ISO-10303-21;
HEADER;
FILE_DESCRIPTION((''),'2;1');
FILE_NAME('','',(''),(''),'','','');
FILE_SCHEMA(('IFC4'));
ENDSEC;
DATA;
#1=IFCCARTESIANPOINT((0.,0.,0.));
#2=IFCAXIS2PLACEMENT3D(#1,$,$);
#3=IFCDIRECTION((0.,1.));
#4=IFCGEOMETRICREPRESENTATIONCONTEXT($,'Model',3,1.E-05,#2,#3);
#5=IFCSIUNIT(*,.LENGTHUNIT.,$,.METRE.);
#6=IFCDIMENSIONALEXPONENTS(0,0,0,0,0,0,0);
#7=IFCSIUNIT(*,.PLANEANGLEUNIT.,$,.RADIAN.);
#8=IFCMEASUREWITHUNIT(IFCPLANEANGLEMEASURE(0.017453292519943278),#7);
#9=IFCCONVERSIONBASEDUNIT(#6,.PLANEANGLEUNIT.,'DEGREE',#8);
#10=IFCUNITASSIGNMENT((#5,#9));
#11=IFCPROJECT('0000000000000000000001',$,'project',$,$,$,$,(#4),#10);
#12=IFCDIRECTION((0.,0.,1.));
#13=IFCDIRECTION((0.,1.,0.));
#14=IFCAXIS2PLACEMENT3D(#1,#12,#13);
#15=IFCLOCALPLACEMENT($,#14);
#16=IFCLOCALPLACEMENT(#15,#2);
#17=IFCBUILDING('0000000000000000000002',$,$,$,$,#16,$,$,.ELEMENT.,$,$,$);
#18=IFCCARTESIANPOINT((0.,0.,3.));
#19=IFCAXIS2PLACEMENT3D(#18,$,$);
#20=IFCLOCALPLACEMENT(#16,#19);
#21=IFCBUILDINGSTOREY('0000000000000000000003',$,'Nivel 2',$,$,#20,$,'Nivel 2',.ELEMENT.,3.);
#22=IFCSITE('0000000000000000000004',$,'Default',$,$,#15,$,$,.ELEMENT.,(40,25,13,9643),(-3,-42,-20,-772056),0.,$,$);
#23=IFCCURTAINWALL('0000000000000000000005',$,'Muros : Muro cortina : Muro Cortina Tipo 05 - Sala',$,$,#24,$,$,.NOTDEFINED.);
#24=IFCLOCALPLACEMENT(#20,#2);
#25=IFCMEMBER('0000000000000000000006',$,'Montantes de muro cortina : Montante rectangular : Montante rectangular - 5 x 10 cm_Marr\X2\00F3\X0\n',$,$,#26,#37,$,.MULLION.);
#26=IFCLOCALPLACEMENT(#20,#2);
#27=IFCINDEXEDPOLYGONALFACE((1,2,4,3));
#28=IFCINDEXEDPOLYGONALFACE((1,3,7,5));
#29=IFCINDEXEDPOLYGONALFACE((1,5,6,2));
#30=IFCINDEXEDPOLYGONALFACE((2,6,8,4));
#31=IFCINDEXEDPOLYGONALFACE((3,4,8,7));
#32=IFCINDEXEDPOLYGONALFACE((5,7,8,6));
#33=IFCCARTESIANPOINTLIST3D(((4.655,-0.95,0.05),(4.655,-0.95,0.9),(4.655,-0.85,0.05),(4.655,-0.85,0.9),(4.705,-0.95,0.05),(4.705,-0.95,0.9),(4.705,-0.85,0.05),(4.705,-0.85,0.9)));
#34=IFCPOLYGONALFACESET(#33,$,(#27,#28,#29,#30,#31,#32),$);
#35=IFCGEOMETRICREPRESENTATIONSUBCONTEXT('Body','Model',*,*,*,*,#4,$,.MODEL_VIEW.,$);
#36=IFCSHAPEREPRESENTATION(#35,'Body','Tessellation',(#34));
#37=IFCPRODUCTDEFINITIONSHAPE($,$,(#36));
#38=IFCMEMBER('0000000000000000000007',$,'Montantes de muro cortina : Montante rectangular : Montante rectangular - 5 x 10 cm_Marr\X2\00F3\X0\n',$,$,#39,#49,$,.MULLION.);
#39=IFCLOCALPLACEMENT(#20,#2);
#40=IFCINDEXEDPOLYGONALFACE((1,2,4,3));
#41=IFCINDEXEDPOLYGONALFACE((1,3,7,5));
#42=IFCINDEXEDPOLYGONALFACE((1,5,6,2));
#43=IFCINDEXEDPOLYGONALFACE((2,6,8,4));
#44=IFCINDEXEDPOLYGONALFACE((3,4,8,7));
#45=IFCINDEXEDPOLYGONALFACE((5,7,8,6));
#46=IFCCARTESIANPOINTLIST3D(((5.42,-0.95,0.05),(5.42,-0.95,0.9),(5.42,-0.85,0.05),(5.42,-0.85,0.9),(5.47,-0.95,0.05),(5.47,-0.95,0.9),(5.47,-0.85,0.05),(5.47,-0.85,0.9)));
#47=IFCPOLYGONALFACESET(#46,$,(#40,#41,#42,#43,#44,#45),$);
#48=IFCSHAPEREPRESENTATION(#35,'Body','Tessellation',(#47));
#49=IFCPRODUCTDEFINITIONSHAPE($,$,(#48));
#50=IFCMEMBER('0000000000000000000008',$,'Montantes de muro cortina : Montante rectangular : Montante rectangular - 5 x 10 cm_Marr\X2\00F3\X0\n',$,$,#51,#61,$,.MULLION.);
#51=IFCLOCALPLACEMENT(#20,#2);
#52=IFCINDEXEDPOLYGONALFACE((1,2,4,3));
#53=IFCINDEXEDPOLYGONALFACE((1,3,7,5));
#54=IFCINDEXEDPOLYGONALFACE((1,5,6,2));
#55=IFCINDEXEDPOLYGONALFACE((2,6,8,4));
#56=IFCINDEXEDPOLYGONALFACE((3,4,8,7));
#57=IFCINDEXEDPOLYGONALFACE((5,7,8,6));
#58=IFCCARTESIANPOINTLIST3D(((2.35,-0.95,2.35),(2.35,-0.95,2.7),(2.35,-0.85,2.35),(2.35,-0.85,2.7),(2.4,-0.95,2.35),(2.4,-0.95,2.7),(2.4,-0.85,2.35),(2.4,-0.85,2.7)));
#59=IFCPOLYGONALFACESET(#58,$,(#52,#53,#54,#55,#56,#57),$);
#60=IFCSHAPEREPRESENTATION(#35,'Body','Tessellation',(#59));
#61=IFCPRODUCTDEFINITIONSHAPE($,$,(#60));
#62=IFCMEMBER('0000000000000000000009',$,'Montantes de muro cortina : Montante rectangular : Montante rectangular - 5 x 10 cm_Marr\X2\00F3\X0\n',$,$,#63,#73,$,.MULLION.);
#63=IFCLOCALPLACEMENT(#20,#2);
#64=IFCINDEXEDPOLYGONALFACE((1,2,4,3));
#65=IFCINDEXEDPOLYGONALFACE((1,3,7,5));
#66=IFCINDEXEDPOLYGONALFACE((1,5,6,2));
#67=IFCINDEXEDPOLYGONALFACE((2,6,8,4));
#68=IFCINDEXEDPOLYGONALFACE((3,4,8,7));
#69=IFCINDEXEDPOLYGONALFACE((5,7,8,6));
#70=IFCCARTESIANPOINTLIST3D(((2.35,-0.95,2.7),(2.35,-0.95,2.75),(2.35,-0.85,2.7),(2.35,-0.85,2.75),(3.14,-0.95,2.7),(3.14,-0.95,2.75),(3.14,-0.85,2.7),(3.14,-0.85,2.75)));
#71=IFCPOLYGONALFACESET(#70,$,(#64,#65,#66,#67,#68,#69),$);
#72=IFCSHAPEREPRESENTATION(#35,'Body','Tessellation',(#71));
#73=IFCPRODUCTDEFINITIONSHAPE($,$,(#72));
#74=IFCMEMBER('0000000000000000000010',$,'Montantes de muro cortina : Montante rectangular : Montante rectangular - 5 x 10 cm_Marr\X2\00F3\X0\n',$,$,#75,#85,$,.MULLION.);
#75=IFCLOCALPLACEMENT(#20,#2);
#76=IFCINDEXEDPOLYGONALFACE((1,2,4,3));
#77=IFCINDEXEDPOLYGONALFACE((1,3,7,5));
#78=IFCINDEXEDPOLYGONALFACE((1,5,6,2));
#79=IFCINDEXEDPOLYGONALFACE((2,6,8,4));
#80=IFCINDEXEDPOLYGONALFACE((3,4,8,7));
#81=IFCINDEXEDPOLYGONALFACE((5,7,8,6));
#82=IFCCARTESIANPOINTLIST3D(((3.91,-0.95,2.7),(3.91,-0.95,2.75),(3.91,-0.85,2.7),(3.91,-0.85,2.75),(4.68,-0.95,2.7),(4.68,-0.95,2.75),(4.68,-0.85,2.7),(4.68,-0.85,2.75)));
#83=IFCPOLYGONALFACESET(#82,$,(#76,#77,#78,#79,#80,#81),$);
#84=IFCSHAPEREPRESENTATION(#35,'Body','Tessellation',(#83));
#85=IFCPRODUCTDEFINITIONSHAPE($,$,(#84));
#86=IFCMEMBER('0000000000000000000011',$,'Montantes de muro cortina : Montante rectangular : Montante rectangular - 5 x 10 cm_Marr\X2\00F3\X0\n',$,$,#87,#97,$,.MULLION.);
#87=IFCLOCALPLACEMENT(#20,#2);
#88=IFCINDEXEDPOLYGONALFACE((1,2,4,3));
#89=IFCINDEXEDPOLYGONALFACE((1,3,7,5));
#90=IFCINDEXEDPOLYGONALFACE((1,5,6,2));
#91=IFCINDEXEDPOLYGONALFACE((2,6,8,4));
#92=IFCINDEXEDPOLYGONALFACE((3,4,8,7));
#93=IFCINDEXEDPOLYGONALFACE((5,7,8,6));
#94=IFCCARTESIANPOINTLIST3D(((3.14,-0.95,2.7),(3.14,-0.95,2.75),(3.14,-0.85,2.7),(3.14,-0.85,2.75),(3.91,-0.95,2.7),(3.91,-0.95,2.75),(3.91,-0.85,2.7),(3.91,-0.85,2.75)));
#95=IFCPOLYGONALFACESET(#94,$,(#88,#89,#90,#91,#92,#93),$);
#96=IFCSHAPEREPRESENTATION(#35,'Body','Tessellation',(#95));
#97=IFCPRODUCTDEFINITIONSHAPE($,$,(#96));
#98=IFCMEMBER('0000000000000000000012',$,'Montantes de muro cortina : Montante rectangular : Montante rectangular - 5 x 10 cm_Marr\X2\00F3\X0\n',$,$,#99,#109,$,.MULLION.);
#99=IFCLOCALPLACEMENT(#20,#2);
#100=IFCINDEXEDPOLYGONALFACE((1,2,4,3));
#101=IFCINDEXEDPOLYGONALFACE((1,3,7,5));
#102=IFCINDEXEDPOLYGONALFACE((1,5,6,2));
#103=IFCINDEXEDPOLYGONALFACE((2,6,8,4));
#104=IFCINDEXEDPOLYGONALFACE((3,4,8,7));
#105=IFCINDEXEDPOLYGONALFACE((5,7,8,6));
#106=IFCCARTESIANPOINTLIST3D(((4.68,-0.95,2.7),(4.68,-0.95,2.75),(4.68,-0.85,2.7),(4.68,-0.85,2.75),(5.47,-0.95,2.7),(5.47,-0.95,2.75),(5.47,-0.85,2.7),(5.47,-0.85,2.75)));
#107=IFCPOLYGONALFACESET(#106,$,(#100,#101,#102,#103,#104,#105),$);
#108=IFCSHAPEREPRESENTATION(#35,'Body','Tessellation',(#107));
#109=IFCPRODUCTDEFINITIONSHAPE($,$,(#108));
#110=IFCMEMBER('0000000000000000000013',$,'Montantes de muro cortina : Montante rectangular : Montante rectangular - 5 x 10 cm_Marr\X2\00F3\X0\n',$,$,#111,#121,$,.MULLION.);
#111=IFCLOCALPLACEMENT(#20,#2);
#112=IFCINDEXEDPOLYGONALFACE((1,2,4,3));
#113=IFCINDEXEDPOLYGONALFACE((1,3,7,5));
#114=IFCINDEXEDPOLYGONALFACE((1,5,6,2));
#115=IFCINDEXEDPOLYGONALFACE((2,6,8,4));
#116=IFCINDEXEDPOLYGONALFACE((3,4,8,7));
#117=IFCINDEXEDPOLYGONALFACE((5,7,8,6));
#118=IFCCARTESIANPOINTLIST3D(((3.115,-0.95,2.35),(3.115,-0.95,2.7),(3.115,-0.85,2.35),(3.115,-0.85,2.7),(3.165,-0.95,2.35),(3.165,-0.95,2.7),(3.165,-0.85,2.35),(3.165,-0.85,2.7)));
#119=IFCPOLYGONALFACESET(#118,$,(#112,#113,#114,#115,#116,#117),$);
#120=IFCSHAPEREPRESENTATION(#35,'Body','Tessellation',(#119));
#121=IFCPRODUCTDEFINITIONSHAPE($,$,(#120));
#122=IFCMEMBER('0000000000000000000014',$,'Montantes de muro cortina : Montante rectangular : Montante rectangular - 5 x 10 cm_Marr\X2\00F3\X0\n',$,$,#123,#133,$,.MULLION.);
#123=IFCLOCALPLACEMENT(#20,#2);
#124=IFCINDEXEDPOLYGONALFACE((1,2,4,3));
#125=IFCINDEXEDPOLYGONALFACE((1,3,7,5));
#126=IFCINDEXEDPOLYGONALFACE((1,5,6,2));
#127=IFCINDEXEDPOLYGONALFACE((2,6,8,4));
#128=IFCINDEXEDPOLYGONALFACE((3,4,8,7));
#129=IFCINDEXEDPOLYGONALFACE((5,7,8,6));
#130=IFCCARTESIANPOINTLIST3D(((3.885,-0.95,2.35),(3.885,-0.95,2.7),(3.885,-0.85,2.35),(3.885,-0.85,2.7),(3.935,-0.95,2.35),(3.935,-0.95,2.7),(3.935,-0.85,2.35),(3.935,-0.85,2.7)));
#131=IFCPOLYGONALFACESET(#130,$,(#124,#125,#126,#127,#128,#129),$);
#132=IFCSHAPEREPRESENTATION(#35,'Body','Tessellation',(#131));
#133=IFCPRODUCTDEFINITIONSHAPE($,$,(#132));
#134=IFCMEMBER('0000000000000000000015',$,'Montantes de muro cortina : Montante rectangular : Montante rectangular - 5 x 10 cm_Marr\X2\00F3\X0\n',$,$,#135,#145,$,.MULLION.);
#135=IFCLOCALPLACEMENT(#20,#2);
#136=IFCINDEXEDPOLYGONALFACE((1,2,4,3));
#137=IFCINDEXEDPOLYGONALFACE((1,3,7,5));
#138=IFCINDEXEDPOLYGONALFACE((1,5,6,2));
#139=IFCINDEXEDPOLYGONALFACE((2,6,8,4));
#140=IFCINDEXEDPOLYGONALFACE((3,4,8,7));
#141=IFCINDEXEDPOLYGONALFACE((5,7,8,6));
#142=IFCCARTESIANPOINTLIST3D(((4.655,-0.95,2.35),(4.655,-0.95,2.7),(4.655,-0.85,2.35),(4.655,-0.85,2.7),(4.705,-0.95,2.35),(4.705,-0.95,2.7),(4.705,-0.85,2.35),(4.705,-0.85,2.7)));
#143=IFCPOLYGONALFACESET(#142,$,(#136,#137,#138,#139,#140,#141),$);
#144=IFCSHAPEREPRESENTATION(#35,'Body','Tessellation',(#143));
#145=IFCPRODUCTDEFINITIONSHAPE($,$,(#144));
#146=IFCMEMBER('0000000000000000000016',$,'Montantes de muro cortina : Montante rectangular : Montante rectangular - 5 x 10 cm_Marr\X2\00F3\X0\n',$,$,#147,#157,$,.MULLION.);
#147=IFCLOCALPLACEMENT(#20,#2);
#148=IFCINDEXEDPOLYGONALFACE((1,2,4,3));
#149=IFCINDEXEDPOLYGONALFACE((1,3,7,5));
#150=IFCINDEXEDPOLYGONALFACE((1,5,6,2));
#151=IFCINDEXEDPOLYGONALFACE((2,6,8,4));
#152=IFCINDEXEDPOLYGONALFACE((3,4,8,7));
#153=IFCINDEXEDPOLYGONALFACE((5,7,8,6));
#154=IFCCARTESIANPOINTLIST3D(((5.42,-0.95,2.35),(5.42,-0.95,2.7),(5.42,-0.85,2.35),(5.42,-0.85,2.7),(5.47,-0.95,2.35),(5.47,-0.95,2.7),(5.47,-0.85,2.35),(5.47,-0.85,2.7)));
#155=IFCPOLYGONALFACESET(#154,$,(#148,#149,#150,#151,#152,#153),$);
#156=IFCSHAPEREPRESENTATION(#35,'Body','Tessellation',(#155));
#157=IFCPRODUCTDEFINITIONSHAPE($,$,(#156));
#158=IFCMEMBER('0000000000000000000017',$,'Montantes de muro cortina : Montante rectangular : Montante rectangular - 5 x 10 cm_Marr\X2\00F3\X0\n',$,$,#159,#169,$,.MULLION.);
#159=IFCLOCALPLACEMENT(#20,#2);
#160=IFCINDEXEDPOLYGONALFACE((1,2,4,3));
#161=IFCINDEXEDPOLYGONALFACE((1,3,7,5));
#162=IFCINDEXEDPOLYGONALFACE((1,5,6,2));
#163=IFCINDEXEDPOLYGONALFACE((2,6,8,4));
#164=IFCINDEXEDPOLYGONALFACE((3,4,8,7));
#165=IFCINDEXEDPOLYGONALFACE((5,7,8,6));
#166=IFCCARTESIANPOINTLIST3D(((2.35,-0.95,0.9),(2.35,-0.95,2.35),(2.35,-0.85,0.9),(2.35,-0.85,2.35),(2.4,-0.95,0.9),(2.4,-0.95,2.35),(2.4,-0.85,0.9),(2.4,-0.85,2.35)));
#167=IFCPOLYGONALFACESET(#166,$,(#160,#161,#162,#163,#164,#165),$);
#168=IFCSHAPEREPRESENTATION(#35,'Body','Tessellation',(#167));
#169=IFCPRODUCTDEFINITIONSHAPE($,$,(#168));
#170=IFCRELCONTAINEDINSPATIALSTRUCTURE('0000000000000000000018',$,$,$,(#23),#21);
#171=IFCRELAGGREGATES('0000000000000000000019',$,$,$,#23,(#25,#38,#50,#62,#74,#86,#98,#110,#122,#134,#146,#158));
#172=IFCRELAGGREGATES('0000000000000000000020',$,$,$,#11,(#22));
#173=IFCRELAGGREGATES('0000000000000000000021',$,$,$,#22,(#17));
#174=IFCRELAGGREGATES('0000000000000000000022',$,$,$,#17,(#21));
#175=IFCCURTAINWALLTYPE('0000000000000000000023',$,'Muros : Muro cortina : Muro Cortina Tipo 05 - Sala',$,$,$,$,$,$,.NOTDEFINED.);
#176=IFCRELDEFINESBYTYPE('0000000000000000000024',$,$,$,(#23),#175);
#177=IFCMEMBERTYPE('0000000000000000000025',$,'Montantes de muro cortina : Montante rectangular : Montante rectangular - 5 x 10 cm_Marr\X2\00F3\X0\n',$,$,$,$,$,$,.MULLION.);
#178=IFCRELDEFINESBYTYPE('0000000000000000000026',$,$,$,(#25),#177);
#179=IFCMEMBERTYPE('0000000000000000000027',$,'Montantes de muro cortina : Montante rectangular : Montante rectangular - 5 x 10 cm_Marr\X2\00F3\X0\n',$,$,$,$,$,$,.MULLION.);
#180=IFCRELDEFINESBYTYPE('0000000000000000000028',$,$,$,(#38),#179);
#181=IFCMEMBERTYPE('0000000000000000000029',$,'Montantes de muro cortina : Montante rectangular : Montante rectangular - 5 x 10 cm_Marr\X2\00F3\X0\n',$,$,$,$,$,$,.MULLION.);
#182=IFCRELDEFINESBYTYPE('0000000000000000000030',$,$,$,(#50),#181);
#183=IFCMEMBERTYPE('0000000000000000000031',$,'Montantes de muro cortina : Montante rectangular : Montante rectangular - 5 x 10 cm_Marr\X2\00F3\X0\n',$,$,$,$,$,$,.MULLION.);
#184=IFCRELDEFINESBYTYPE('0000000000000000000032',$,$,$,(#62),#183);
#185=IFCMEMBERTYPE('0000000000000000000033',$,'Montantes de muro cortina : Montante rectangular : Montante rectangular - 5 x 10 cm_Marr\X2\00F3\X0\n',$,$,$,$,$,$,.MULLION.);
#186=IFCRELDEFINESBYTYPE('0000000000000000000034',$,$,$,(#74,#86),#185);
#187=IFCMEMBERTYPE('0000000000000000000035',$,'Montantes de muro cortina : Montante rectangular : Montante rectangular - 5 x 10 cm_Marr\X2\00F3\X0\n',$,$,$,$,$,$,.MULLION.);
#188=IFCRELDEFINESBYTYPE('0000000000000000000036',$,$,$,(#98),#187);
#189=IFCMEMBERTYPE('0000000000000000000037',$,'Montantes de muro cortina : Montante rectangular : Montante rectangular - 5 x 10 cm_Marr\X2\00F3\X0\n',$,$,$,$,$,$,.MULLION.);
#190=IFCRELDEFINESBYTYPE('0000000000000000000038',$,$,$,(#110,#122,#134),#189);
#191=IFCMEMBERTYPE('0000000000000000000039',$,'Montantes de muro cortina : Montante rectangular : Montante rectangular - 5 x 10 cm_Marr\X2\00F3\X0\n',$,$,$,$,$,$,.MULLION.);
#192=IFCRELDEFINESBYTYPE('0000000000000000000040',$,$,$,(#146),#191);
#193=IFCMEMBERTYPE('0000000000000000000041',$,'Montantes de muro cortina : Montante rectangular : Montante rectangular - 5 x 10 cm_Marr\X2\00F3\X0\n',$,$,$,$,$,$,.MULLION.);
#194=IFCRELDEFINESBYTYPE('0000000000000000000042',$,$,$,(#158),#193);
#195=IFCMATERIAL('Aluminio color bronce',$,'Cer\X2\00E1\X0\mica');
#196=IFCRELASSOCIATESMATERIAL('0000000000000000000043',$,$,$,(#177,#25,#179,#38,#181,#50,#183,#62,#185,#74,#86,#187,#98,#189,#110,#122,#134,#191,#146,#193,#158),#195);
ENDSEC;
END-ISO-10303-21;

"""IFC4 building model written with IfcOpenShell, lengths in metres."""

from ifc_helpers import new_model, entity, si_unit, converted_unit, direction, frame, origin, place, context, subcontext, project, spatial, indexed_curve, outline, extrude, source, transform, mapped, material, type_object, type_shapes, element, aggregate, save


model = new_model("IFC4")

# Units and contexts
model_context = context("Model", 3, precision=1e-05, world=origin(), true_north=direction((0.0, 1.0)))
body_context = subcontext(model_context, "Body", "Model", "MODEL_VIEW")
ifc_project = project(units=[si_unit("LENGTHUNIT", "METRE"), converted_unit("PLANEANGLEUNIT", "DEGREE", entity("IfcPlaneAngleMeasure", 0.017453292519943278), si_unit("PLANEANGLEUNIT", "RADIAN"), dimensions=[0, 0, 0, 0, 0, 0, 0])], contexts=[model_context])

# Site, building, storey
site_placement = place(None, frame((0.0, 0.0, 0.0), z_axis=(0.0, 0.0, 1.0), x_axis=(0.0, 1.0, 0.0)))
site = spatial("IfcSite", under=ifc_project, at=site_placement, Name="Default", CompositionType="ELEMENT", RefLatitude=(40, 25, 13, 9643), RefLongitude=(-3, -42, -20, -772056), RefElevation=0.0)
building_placement = place(site_placement, origin())
building = spatial("IfcBuilding", under=site, at=building_placement, CompositionType="ELEMENT")
storey_placement = place(building_placement, frame((0.0, 0.0, 3.0)))
storey = spatial("IfcBuildingStorey", under=building, at=storey_placement, Name="Nivel 2", LongName="Nivel 2", CompositionType="ELEMENT", Elevation=3.0)

# Curtain wall, members
curtain_wall_type = type_object("IfcCurtainWallType", Name="Muros : Muro cortina : Muro Cortina Tipo 05 - Sala", PredefinedType="NOTDEFINED")
curtain_wall_placement = place(storey_placement, frame((0.0, 0.0, -3.0)))
curtain_wall = element("IfcCurtainWall", 1, at=curtain_wall_placement, inside=storey, type_object=curtain_wall_type, Name="Muros : Muro cortina : Muro Cortina Tipo 05 - Sala", PredefinedType="NOTDEFINED")
ifc_material_1 = material(Name="Aluminio color bronce", Category="Cerámica")
member_type_1 = type_object("IfcMemberType", Name="Montantes de muro cortina : Montante rectangular : Montante rectangular - 5 x 10 cm_Marrón", PredefinedType="MULLION", material=ifc_material_1)
shared_shape_1 = source(origin(), body_context, "Body", "SweptSolid", [
    extrude(outline(indexed_curve([(-0.05, -0.025), (0.05, -0.025), (0.05, 0.025), (-0.05, 0.025), (-0.05, -0.025)], self_intersect=False)), frame((0.0, 0.0, -0.85), z_axis=(0.0, 0.0, 1.0), x_axis=(0.0, 1.0, 0.0)), (0.0, 0.0, 1.0), 0.85),
])
type_shapes(member_type_1, [shared_shape_1])
member_1_placement = place(curtain_wall_placement, frame((4.68, -0.9, 3.05), z_axis=(0.0, 0.0, -1.0), x_axis=(1.0, 0.0, 0.0)))
member_1 = element("IfcMember", 2, at=member_1_placement, type_object=member_type_1, material=ifc_material_1, Name="Montantes de muro cortina : Montante rectangular : Montante rectangular - 5 x 10 cm_Marrón", PredefinedType="MULLION", context=body_context, shape_type="MappedRepresentation", body=[
    mapped(shared_shape_1, transform((0.0, 0.0, 0.0), scale=1.0)),
])
member_type_2 = type_object("IfcMemberType", Name="Montantes de muro cortina : Montante rectangular : Montante rectangular - 5 x 10 cm_Marrón", PredefinedType="MULLION", material=ifc_material_1)
shared_shape_2 = source(origin(), body_context, "Body", "SweptSolid", [
    extrude(outline(indexed_curve([(-0.05, -0.025), (0.05, -0.025), (0.05, 0.025), (-0.05, 0.025), (-0.05, -0.025)], self_intersect=False)), frame((-0.025, 0.0, -0.85), z_axis=(0.0, 0.0, 1.0), x_axis=(0.0, 1.0, 0.0)), (0.0, 0.0, 1.0), 0.85),
])
type_shapes(member_type_2, [shared_shape_2])
member_2_placement = place(curtain_wall_placement, frame((5.47, -0.9, 3.05), z_axis=(0.0, 0.0, -1.0), x_axis=(1.0, 0.0, 0.0)))
member_2 = element("IfcMember", 3, at=member_2_placement, type_object=member_type_2, material=ifc_material_1, Name="Montantes de muro cortina : Montante rectangular : Montante rectangular - 5 x 10 cm_Marrón", PredefinedType="MULLION", context=body_context, shape_type="MappedRepresentation", body=[
    mapped(shared_shape_2, transform((0.0, 0.0, 0.0), scale=1.0)),
])
member_type_3 = type_object("IfcMemberType", Name="Montantes de muro cortina : Montante rectangular : Montante rectangular - 5 x 10 cm_Marrón", PredefinedType="MULLION", material=ifc_material_1)
shared_shape_3 = source(origin(), body_context, "Body", "SweptSolid", [
    extrude(outline(indexed_curve([(-0.025, -0.05), (0.025, -0.05), (0.025, 0.05), (-0.025, 0.05), (-0.025, -0.05)], self_intersect=False)), frame((-0.025, 0.0, -0.35)), (0.0, 0.0, 1.0), 0.35),
])
type_shapes(member_type_3, [shared_shape_3])
member_3_placement = place(curtain_wall_placement, frame((2.35, -0.9, 5.7), z_axis=(0.0, 0.0, 1.0), x_axis=(-1.0, 0.0, 0.0)))
member_3 = element("IfcMember", 4, at=member_3_placement, type_object=member_type_3, material=ifc_material_1, Name="Montantes de muro cortina : Montante rectangular : Montante rectangular - 5 x 10 cm_Marrón", PredefinedType="MULLION", context=body_context, shape_type="MappedRepresentation", body=[
    mapped(shared_shape_3, transform((0.0, 0.0, 0.0), scale=1.0)),
])
member_type_4 = type_object("IfcMemberType", Name="Montantes de muro cortina : Montante rectangular : Montante rectangular - 5 x 10 cm_Marrón", PredefinedType="MULLION", material=ifc_material_1)
shared_shape_4 = source(origin(), body_context, "Body", "SweptSolid", [
    extrude(outline(indexed_curve([(-0.05, -0.025), (0.05, -0.025), (0.05, 0.025), (-0.05, 0.025), (-0.05, -0.025)], self_intersect=False)), frame((-0.025, 0.0, -0.79), z_axis=(0.0, 0.0, 1.0), x_axis=(0.0, 1.0, 0.0)), (0.0, 0.0, 1.0), 0.79),
])
type_shapes(member_type_4, [shared_shape_4])
member_4_placement = place(curtain_wall_placement, frame((3.14, -0.9, 5.75), z_axis=(1.0, 0.0, 0.0), x_axis=(0.0, 0.0, 1.0)))
member_4 = element("IfcMember", 5, at=member_4_placement, type_object=member_type_4, material=ifc_material_1, Name="Montantes de muro cortina : Montante rectangular : Montante rectangular - 5 x 10 cm_Marrón", PredefinedType="MULLION", context=body_context, shape_type="MappedRepresentation", body=[
    mapped(shared_shape_4, transform((0.0, 0.0, 0.0), scale=1.0)),
])
member_type_5 = type_object("IfcMemberType", Name="Montantes de muro cortina : Montante rectangular : Montante rectangular - 5 x 10 cm_Marrón", PredefinedType="MULLION", material=ifc_material_1)
shared_shape_5 = source(origin(), body_context, "Body", "SweptSolid", [
    extrude(outline(indexed_curve([(-0.05, -0.025), (0.05, -0.025), (0.05, 0.025), (-0.05, 0.025), (-0.05, -0.025)], self_intersect=False)), frame((-0.025, 0.0, -0.77), z_axis=(0.0, 0.0, 1.0), x_axis=(0.0, 1.0, 0.0)), (0.0, 0.0, 1.0), 0.77),
])
type_shapes(member_type_5, [shared_shape_5])
member_5_placement = place(curtain_wall_placement, frame((4.68, -0.9, 5.75), z_axis=(1.0, 0.0, 0.0), x_axis=(0.0, 0.0, 1.0)))
member_5 = element("IfcMember", 6, at=member_5_placement, type_object=member_type_5, material=ifc_material_1, Name="Montantes de muro cortina : Montante rectangular : Montante rectangular - 5 x 10 cm_Marrón", PredefinedType="MULLION", context=body_context, shape_type="MappedRepresentation", body=[
    mapped(shared_shape_5, transform((0.0, 0.0, 0.0), scale=1.0)),
])
member_6_placement = place(curtain_wall_placement, frame((3.91, -0.9, 5.75), z_axis=(1.0, 0.0, 0.0), x_axis=(0.0, 0.0, 1.0)))
member_6 = element("IfcMember", 7, at=member_6_placement, type_object=member_type_5, material=ifc_material_1, Name="Montantes de muro cortina : Montante rectangular : Montante rectangular - 5 x 10 cm_Marrón", PredefinedType="MULLION", context=body_context, shape_type="MappedRepresentation", body=[
    mapped(shared_shape_5, transform((0.0, 0.0, 0.0), scale=1.0)),
])
member_type_6 = type_object("IfcMemberType", Name="Montantes de muro cortina : Montante rectangular : Montante rectangular - 5 x 10 cm_Marrón", PredefinedType="MULLION", material=ifc_material_1)
shared_shape_6 = source(origin(), body_context, "Body", "SweptSolid", [
    extrude(outline(indexed_curve([(-0.05, -0.025), (0.05, -0.025), (0.05, 0.025), (-0.05, 0.025), (-0.05, -0.025)], self_intersect=False)), frame((-0.025, 0.0, -0.79), z_axis=(0.0, 0.0, 1.0), x_axis=(0.0, 1.0, 0.0)), (0.0, 0.0, 1.0), 0.79),
])
type_shapes(member_type_6, [shared_shape_6])
member_7_placement = place(curtain_wall_placement, frame((5.47, -0.9, 5.75), z_axis=(1.0, 0.0, 0.0), x_axis=(0.0, 0.0, 1.0)))
member_7 = element("IfcMember", 8, at=member_7_placement, type_object=member_type_6, material=ifc_material_1, Name="Montantes de muro cortina : Montante rectangular : Montante rectangular - 5 x 10 cm_Marrón", PredefinedType="MULLION", context=body_context, shape_type="MappedRepresentation", body=[
    mapped(shared_shape_6, transform((0.0, 0.0, 0.0), scale=1.0)),
])
member_type_7 = type_object("IfcMemberType", Name="Montantes de muro cortina : Montante rectangular : Montante rectangular - 5 x 10 cm_Marrón", PredefinedType="MULLION", material=ifc_material_1)
shared_shape_7 = source(origin(), body_context, "Body", "SweptSolid", [
    extrude(outline(indexed_curve([(-0.05, -0.025), (0.05, -0.025), (0.05, 0.025), (-0.05, 0.025), (-0.05, -0.025)], self_intersect=False)), frame((0.0, 0.0, -0.35), z_axis=(0.0, 0.0, 1.0), x_axis=(0.0, 1.0, 0.0)), (0.0, 0.0, 1.0), 0.35),
])
type_shapes(member_type_7, [shared_shape_7])
member_8_placement = place(curtain_wall_placement, frame((3.14, -0.9, 5.35), z_axis=(0.0, 0.0, -1.0), x_axis=(1.0, 0.0, 0.0)))
member_8 = element("IfcMember", 9, at=member_8_placement, type_object=member_type_7, material=ifc_material_1, Name="Montantes de muro cortina : Montante rectangular : Montante rectangular - 5 x 10 cm_Marrón", PredefinedType="MULLION", context=body_context, shape_type="MappedRepresentation", body=[
    mapped(shared_shape_7, transform((0.0, 0.0, 0.0), scale=1.0)),
])
member_9_placement = place(curtain_wall_placement, frame((3.91, -0.9, 5.35), z_axis=(0.0, 0.0, -1.0), x_axis=(1.0, 0.0, 0.0)))
member_9 = element("IfcMember", 10, at=member_9_placement, type_object=member_type_7, material=ifc_material_1, Name="Montantes de muro cortina : Montante rectangular : Montante rectangular - 5 x 10 cm_Marrón", PredefinedType="MULLION", context=body_context, shape_type="MappedRepresentation", body=[
    mapped(shared_shape_7, transform((0.0, 0.0, 0.0), scale=1.0)),
])
member_10_placement = place(curtain_wall_placement, frame((4.68, -0.9, 5.35), z_axis=(0.0, 0.0, -1.0), x_axis=(1.0, 0.0, 0.0)))
member_10 = element("IfcMember", 11, at=member_10_placement, type_object=member_type_7, material=ifc_material_1, Name="Montantes de muro cortina : Montante rectangular : Montante rectangular - 5 x 10 cm_Marrón", PredefinedType="MULLION", context=body_context, shape_type="MappedRepresentation", body=[
    mapped(shared_shape_7, transform((0.0, 0.0, 0.0), scale=1.0)),
])
member_type_8 = type_object("IfcMemberType", Name="Montantes de muro cortina : Montante rectangular : Montante rectangular - 5 x 10 cm_Marrón", PredefinedType="MULLION", material=ifc_material_1)
shared_shape_8 = source(origin(), body_context, "Body", "SweptSolid", [
    extrude(outline(indexed_curve([(-0.05, -0.025), (0.05, -0.025), (0.05, 0.025), (-0.05, 0.025), (-0.05, -0.025)], self_intersect=False)), frame((-0.025, 0.0, -0.35), z_axis=(0.0, 0.0, 1.0), x_axis=(0.0, 1.0, 0.0)), (0.0, 0.0, 1.0), 0.35),
])
type_shapes(member_type_8, [shared_shape_8])
member_11_placement = place(curtain_wall_placement, frame((5.47, -0.9, 5.35), z_axis=(0.0, 0.0, -1.0), x_axis=(1.0, 0.0, 0.0)))
member_11 = element("IfcMember", 12, at=member_11_placement, type_object=member_type_8, material=ifc_material_1, Name="Montantes de muro cortina : Montante rectangular : Montante rectangular - 5 x 10 cm_Marrón", PredefinedType="MULLION", context=body_context, shape_type="MappedRepresentation", body=[
    mapped(shared_shape_8, transform((0.0, 0.0, 0.0), scale=1.0)),
])
member_type_9 = type_object("IfcMemberType", Name="Montantes de muro cortina : Montante rectangular : Montante rectangular - 5 x 10 cm_Marrón", PredefinedType="MULLION", material=ifc_material_1)
shared_shape_9 = source(origin(), body_context, "Body", "SweptSolid", [
    extrude(outline(indexed_curve([(-0.025, -0.05), (0.025, -0.05), (0.025, 0.05), (-0.025, 0.05), (-0.025, -0.05)], self_intersect=False)), frame((-0.025, 0.0, -1.45)), (0.0, 0.0, 1.0), 1.45),
])
type_shapes(member_type_9, [shared_shape_9])
member_12_placement = place(curtain_wall_placement, frame((2.35, -0.9, 5.35), z_axis=(0.0, 0.0, 1.0), x_axis=(-1.0, 0.0, 0.0)))
member_12 = element("IfcMember", 13, at=member_12_placement, type_object=member_type_9, material=ifc_material_1, Name="Montantes de muro cortina : Montante rectangular : Montante rectangular - 5 x 10 cm_Marrón", PredefinedType="MULLION", context=body_context, shape_type="MappedRepresentation", body=[
    mapped(shared_shape_9, transform((0.0, 0.0, 0.0), scale=1.0)),
])
aggregate(curtain_wall, [member_1, member_2, member_3, member_4, member_5, member_6, member_7, member_8, member_9, member_10, member_11, member_12])

save(model, "model.ifc")
